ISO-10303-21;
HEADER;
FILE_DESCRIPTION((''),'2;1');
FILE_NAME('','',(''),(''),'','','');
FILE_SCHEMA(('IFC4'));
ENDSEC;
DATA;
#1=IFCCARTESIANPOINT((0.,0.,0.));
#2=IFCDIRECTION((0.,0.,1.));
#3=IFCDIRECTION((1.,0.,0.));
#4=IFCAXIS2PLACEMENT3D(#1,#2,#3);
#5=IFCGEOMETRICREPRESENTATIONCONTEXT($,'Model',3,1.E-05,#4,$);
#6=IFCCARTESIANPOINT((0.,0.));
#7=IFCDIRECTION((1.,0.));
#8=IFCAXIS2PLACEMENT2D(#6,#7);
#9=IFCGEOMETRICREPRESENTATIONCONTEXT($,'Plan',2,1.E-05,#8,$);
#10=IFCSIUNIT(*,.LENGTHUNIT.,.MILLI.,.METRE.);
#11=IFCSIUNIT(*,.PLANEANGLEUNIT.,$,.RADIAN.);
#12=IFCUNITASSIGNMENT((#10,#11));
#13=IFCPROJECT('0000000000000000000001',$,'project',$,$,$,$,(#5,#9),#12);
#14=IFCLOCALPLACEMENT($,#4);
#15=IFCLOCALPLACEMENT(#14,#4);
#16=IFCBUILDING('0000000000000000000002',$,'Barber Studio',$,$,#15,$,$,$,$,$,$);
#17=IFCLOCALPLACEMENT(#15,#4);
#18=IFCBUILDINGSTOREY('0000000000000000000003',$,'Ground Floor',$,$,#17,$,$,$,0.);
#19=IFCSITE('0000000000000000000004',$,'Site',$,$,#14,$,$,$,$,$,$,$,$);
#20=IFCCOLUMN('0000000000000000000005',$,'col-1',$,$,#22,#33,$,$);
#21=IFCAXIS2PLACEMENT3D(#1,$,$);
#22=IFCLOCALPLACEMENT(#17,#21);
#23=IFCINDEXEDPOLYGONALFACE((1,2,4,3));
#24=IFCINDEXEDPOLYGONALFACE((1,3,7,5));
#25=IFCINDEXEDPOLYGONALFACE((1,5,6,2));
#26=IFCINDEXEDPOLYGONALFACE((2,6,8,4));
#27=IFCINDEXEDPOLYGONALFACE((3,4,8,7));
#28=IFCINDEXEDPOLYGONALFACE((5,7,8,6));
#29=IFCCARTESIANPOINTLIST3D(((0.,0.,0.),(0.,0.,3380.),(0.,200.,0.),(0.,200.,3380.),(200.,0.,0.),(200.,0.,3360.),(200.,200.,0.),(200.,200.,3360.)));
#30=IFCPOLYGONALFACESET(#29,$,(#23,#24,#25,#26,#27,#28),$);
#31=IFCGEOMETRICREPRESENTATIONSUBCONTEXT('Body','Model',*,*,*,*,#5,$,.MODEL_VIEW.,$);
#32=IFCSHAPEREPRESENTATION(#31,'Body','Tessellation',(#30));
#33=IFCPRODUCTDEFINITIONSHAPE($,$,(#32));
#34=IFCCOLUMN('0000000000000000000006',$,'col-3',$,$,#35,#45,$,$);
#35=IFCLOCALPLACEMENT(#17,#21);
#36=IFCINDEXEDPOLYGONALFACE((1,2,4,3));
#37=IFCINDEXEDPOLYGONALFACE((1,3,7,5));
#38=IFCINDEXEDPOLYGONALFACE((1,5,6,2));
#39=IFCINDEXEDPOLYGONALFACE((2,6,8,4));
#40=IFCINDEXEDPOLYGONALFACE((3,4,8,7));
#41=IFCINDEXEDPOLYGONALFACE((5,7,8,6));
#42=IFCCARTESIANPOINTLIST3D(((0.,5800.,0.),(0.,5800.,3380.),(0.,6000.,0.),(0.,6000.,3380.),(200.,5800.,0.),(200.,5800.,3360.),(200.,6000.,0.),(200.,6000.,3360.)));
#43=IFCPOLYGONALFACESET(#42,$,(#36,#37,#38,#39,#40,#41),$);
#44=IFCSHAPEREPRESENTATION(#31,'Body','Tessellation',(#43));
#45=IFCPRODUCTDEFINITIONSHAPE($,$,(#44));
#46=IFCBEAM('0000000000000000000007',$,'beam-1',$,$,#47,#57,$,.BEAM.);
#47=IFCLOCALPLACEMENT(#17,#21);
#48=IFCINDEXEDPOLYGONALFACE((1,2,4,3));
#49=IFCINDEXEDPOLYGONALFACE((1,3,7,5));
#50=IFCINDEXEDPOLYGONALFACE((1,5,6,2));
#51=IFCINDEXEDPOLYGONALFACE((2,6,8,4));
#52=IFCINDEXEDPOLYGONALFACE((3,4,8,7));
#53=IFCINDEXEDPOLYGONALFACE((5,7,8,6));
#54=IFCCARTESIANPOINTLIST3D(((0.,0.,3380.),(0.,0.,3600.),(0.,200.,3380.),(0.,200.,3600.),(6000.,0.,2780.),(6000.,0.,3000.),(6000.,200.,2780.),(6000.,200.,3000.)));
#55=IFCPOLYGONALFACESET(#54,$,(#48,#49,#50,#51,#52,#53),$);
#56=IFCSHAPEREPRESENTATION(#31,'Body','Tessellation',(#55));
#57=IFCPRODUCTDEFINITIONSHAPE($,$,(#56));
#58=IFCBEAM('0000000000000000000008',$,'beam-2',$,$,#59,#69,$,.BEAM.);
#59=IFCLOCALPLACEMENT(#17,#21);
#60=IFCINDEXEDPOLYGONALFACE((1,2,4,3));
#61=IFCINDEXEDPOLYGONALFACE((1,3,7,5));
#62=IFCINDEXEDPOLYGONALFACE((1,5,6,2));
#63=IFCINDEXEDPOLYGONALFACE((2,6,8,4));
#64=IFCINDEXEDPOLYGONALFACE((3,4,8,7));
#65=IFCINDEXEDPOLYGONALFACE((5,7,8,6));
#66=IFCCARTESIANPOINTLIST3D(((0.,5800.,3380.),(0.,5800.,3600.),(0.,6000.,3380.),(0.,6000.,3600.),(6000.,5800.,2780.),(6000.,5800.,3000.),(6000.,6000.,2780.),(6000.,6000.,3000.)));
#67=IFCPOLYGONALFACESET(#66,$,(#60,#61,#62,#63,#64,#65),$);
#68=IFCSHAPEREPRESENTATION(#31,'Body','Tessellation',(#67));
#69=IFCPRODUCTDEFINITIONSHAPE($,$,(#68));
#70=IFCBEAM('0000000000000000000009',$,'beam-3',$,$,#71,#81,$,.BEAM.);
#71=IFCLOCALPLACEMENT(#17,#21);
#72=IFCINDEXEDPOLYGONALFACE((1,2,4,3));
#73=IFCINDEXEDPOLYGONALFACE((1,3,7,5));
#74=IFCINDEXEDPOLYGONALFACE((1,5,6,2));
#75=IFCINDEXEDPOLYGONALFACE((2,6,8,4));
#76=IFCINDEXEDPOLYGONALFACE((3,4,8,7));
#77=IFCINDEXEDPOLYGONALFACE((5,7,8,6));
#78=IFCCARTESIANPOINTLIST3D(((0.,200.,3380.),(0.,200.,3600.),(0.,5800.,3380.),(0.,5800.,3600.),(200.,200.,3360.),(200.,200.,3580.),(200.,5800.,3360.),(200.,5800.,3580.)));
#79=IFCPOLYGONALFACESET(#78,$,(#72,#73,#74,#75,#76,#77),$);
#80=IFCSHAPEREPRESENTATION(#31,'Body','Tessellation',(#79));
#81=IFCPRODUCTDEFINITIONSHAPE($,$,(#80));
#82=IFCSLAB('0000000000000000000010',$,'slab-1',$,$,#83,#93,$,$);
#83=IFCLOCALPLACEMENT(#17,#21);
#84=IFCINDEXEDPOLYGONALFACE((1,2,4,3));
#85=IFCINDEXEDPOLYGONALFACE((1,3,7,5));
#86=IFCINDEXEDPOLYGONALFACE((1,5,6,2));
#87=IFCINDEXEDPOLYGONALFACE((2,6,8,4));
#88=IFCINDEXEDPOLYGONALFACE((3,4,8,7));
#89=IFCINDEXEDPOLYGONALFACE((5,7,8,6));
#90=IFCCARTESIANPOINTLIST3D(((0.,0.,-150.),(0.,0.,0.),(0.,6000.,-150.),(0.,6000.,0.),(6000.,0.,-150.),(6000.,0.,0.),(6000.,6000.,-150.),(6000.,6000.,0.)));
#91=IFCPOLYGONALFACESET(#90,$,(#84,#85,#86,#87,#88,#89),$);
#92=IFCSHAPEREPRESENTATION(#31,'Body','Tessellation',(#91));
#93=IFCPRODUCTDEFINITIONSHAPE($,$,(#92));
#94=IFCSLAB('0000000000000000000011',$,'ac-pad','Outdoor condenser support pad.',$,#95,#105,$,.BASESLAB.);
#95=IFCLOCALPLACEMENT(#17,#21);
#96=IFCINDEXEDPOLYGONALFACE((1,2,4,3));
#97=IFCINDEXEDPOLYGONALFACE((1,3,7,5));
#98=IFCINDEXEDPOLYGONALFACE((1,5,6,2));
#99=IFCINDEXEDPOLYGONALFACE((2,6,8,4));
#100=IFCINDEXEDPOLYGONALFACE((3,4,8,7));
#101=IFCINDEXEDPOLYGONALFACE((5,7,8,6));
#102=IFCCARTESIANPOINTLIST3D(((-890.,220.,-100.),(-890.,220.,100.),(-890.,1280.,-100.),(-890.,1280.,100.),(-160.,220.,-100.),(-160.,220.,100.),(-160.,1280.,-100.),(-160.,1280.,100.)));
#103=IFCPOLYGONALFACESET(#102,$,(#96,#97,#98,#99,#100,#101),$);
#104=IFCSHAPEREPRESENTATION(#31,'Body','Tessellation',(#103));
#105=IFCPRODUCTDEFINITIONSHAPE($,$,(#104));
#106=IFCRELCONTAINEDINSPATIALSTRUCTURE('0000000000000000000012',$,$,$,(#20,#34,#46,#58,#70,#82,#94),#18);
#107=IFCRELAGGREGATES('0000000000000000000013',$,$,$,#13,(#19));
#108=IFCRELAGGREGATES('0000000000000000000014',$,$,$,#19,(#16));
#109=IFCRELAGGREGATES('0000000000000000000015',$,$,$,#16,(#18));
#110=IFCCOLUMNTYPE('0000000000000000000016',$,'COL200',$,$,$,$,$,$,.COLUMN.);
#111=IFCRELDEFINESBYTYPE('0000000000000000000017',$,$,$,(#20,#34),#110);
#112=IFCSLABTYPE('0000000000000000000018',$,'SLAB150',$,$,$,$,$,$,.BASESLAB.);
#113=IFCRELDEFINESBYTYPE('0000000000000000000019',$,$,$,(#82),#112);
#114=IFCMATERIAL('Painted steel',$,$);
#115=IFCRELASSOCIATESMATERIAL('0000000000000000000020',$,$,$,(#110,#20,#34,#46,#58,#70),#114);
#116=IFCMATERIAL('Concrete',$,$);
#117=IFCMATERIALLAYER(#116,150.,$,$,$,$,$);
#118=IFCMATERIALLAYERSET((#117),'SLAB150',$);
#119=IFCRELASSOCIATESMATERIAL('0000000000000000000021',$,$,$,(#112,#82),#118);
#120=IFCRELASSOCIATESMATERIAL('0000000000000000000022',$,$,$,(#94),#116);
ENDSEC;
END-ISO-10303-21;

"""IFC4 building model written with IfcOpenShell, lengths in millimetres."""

from ifc_helpers import new_model, si_unit, frame, origin_with_axes, origin_2d_with_axis, place, context, subcontext, project, spatial, line, indexed_curve, rectangle, outline, extrude, clip, halfspace, material, layer, layer_set, layer_usage, material_profile, profile_set, profile_usage, type_object, element, save


model = new_model("IFC4")

# Units and contexts
model_context = context("Model", 3, precision=1e-05, world=origin_with_axes())
plan_context = context("Plan", 2, precision=1e-05, world=origin_2d_with_axis())
body_context_1 = subcontext(model_context, "Body", "Model", "MODEL_VIEW")
ifc_project = project(units=[si_unit("LENGTHUNIT", "METRE", prefix="MILLI"), si_unit("PLANEANGLEUNIT", "RADIAN")], contexts=[model_context, plan_context])

# Site, building, storey
site_placement = place(None, origin_with_axes())
site = spatial("IfcSite", under=ifc_project, at=site_placement, Name="Site")
building_placement = place(site_placement, origin_with_axes())
building = spatial("IfcBuilding", under=site, at=building_placement, Name="Barber Studio")
storey_placement = place(building_placement, origin_with_axes())
storey = spatial("IfcBuildingStorey", under=building, at=storey_placement, Name="Ground Floor", Elevation=0.0)

# Columns
ifc_material_1 = material(Name="Painted steel")
ifc_material_profile = material_profile(ifc_material_1, rectangle(XDim=200.0, YDim=200.0))
ifc_profile_set = profile_set([ifc_material_profile])
ifc_profile_usage_1 = profile_usage(ifc_profile_set, cardinal=5)
column_type = type_object("IfcColumnType", Name="COL200", PredefinedType="COLUMN", material=ifc_profile_set)
column_1_placement = place(storey_placement, frame((100.0, 100.0, 0.0), z_axis=(0.0, 0.0, 1.0), x_axis=(1.0, 0.0, 0.0)))
element("IfcColumn", 1, at=column_1_placement, inside=storey, type_object=column_type, material=ifc_profile_usage_1, Name="col-1", context=body_context_1, shape_type="Clipping", body=[
    clip(extrude(rectangle(XDim=200.0, YDim=200.0), origin_with_axes(), (0.0, 0.0, 1.0), 3600.0), halfspace(frame((0.0, 0.0, 3370.0), z_axis=(0.1, 0.0, 1.0), x_axis=(0.0, -1.0, 0.0)), False)),
])
ifc_profile_usage_2 = profile_usage(ifc_profile_set, cardinal=5)
column_2_placement = place(storey_placement, frame((100.0, 5900.0, 0.0), z_axis=(0.0, 0.0, 1.0), x_axis=(1.0, 0.0, 0.0)))
element("IfcColumn", 2, at=column_2_placement, inside=storey, type_object=column_type, material=ifc_profile_usage_2, Name="col-3", context=body_context_1, shape_type="Clipping", body=[
    clip(extrude(rectangle(XDim=200.0, YDim=200.0), origin_with_axes(), (0.0, 0.0, 1.0), 3600.0), halfspace(frame((0.0, 0.0, 3370.0), z_axis=(0.1, 0.0, 1.0), x_axis=(0.0, -1.0, 0.0)), False)),
])

# Beams
for number, where, z_axis, x_axis, name in (
    (3, (0.0, 0.0, 3380.0), (0.0, 0.0, 1.0), (1.0, 0.0, 0.0), "beam-1"),
    (4, (0.0, 5800.0, 3380.0), (0.0, 0.0, 1.0), (1.0, 0.0, 0.0), "beam-2"),
):
    element("IfcBeam", number, at=place(storey_placement, frame(where, z_axis=z_axis, x_axis=x_axis)), inside=storey, material=ifc_material_1, Name=name, PredefinedType="BEAM", context=body_context_1, shape_type="SweptSolid", body=[
        extrude(outline(indexed_curve([(0.0, 0.0), (6000.0, -600.0), (6000.0, -380.0), (0.0, 220.0)], segments=[line(1, 2, 3, 4, 1)])), frame((0.0, 0.0, 0.0), z_axis=(0.0, -1.0, 0.0), x_axis=(1.0, 0.0, 0.0)), (0.0, 0.0, -1.0), 200.0),
    ])
beam_placement = place(storey_placement, frame((0.0, 200.0, 3380.0), z_axis=(0.0, 0.0, 1.0), x_axis=(1.0, 0.0, 0.0)))
element("IfcBeam", 5, at=beam_placement, inside=storey, material=ifc_material_1, Name="beam-3", PredefinedType="BEAM", context=body_context_1, shape_type="SweptSolid", body=[
    extrude(outline(indexed_curve([(0.0, 0.0), (200.0, -20.0), (200.0, 200.0), (0.0, 220.0)], segments=[line(1, 2, 3, 4, 1)])), frame((0.0, 0.0, 0.0), z_axis=(0.0, -1.0, 0.0), x_axis=(1.0, 0.0, 0.0)), (0.0, 0.0, -1.0), 5600.0),
])

# Slabs
ifc_material_2 = material(Name="Concrete")
ifc_layer_1 = layer(ifc_material_2, 150.0)
ifc_layer_set_1 = layer_set([ifc_layer_1], Name="SLAB150")
ifc_layer_usage_1 = layer_usage(ifc_layer_set_1, "AXIS3", "NEGATIVE", 0.0)
slab_type = type_object("IfcSlabType", Name="SLAB150", PredefinedType="BASESLAB", material=ifc_layer_set_1)
slab_1_placement = place(storey_placement, origin_with_axes())
element("IfcSlab", 6, at=slab_1_placement, inside=storey, type_object=slab_type, material=ifc_layer_usage_1, Name="slab-1", context=body_context_1, shape_type="SweptSolid", body=[
    extrude(outline(indexed_curve([(0.0, 0.0), (6000.0, 0.0), (6000.0, 6000.0), (0.0, 6000.0)])), None, (0.0, 0.0, -1.0), 150.0),
])
slab_2_placement = place(storey_placement, frame((-890.0, 220.0, -100.0), z_axis=(0.0, 0.0, 1.0), x_axis=(1.0, 0.0, 0.0)))
element("IfcSlab", 7, at=slab_2_placement, inside=storey, material=ifc_material_2, Name="ac-pad", Description="Outdoor condenser support pad.", PredefinedType="BASESLAB", context=body_context_1, shape_type="SweptSolid", body=[
    extrude(outline(indexed_curve([(0.0, 0.0), (730.0, 0.0), (730.0, 1060.0), (0.0, 1060.0)], segments=[line(1, 2, 3, 4, 1)])), origin_with_axes(), (0.0, 0.0, 1.0), 200.0),
])

save(model, "model.ifc")
